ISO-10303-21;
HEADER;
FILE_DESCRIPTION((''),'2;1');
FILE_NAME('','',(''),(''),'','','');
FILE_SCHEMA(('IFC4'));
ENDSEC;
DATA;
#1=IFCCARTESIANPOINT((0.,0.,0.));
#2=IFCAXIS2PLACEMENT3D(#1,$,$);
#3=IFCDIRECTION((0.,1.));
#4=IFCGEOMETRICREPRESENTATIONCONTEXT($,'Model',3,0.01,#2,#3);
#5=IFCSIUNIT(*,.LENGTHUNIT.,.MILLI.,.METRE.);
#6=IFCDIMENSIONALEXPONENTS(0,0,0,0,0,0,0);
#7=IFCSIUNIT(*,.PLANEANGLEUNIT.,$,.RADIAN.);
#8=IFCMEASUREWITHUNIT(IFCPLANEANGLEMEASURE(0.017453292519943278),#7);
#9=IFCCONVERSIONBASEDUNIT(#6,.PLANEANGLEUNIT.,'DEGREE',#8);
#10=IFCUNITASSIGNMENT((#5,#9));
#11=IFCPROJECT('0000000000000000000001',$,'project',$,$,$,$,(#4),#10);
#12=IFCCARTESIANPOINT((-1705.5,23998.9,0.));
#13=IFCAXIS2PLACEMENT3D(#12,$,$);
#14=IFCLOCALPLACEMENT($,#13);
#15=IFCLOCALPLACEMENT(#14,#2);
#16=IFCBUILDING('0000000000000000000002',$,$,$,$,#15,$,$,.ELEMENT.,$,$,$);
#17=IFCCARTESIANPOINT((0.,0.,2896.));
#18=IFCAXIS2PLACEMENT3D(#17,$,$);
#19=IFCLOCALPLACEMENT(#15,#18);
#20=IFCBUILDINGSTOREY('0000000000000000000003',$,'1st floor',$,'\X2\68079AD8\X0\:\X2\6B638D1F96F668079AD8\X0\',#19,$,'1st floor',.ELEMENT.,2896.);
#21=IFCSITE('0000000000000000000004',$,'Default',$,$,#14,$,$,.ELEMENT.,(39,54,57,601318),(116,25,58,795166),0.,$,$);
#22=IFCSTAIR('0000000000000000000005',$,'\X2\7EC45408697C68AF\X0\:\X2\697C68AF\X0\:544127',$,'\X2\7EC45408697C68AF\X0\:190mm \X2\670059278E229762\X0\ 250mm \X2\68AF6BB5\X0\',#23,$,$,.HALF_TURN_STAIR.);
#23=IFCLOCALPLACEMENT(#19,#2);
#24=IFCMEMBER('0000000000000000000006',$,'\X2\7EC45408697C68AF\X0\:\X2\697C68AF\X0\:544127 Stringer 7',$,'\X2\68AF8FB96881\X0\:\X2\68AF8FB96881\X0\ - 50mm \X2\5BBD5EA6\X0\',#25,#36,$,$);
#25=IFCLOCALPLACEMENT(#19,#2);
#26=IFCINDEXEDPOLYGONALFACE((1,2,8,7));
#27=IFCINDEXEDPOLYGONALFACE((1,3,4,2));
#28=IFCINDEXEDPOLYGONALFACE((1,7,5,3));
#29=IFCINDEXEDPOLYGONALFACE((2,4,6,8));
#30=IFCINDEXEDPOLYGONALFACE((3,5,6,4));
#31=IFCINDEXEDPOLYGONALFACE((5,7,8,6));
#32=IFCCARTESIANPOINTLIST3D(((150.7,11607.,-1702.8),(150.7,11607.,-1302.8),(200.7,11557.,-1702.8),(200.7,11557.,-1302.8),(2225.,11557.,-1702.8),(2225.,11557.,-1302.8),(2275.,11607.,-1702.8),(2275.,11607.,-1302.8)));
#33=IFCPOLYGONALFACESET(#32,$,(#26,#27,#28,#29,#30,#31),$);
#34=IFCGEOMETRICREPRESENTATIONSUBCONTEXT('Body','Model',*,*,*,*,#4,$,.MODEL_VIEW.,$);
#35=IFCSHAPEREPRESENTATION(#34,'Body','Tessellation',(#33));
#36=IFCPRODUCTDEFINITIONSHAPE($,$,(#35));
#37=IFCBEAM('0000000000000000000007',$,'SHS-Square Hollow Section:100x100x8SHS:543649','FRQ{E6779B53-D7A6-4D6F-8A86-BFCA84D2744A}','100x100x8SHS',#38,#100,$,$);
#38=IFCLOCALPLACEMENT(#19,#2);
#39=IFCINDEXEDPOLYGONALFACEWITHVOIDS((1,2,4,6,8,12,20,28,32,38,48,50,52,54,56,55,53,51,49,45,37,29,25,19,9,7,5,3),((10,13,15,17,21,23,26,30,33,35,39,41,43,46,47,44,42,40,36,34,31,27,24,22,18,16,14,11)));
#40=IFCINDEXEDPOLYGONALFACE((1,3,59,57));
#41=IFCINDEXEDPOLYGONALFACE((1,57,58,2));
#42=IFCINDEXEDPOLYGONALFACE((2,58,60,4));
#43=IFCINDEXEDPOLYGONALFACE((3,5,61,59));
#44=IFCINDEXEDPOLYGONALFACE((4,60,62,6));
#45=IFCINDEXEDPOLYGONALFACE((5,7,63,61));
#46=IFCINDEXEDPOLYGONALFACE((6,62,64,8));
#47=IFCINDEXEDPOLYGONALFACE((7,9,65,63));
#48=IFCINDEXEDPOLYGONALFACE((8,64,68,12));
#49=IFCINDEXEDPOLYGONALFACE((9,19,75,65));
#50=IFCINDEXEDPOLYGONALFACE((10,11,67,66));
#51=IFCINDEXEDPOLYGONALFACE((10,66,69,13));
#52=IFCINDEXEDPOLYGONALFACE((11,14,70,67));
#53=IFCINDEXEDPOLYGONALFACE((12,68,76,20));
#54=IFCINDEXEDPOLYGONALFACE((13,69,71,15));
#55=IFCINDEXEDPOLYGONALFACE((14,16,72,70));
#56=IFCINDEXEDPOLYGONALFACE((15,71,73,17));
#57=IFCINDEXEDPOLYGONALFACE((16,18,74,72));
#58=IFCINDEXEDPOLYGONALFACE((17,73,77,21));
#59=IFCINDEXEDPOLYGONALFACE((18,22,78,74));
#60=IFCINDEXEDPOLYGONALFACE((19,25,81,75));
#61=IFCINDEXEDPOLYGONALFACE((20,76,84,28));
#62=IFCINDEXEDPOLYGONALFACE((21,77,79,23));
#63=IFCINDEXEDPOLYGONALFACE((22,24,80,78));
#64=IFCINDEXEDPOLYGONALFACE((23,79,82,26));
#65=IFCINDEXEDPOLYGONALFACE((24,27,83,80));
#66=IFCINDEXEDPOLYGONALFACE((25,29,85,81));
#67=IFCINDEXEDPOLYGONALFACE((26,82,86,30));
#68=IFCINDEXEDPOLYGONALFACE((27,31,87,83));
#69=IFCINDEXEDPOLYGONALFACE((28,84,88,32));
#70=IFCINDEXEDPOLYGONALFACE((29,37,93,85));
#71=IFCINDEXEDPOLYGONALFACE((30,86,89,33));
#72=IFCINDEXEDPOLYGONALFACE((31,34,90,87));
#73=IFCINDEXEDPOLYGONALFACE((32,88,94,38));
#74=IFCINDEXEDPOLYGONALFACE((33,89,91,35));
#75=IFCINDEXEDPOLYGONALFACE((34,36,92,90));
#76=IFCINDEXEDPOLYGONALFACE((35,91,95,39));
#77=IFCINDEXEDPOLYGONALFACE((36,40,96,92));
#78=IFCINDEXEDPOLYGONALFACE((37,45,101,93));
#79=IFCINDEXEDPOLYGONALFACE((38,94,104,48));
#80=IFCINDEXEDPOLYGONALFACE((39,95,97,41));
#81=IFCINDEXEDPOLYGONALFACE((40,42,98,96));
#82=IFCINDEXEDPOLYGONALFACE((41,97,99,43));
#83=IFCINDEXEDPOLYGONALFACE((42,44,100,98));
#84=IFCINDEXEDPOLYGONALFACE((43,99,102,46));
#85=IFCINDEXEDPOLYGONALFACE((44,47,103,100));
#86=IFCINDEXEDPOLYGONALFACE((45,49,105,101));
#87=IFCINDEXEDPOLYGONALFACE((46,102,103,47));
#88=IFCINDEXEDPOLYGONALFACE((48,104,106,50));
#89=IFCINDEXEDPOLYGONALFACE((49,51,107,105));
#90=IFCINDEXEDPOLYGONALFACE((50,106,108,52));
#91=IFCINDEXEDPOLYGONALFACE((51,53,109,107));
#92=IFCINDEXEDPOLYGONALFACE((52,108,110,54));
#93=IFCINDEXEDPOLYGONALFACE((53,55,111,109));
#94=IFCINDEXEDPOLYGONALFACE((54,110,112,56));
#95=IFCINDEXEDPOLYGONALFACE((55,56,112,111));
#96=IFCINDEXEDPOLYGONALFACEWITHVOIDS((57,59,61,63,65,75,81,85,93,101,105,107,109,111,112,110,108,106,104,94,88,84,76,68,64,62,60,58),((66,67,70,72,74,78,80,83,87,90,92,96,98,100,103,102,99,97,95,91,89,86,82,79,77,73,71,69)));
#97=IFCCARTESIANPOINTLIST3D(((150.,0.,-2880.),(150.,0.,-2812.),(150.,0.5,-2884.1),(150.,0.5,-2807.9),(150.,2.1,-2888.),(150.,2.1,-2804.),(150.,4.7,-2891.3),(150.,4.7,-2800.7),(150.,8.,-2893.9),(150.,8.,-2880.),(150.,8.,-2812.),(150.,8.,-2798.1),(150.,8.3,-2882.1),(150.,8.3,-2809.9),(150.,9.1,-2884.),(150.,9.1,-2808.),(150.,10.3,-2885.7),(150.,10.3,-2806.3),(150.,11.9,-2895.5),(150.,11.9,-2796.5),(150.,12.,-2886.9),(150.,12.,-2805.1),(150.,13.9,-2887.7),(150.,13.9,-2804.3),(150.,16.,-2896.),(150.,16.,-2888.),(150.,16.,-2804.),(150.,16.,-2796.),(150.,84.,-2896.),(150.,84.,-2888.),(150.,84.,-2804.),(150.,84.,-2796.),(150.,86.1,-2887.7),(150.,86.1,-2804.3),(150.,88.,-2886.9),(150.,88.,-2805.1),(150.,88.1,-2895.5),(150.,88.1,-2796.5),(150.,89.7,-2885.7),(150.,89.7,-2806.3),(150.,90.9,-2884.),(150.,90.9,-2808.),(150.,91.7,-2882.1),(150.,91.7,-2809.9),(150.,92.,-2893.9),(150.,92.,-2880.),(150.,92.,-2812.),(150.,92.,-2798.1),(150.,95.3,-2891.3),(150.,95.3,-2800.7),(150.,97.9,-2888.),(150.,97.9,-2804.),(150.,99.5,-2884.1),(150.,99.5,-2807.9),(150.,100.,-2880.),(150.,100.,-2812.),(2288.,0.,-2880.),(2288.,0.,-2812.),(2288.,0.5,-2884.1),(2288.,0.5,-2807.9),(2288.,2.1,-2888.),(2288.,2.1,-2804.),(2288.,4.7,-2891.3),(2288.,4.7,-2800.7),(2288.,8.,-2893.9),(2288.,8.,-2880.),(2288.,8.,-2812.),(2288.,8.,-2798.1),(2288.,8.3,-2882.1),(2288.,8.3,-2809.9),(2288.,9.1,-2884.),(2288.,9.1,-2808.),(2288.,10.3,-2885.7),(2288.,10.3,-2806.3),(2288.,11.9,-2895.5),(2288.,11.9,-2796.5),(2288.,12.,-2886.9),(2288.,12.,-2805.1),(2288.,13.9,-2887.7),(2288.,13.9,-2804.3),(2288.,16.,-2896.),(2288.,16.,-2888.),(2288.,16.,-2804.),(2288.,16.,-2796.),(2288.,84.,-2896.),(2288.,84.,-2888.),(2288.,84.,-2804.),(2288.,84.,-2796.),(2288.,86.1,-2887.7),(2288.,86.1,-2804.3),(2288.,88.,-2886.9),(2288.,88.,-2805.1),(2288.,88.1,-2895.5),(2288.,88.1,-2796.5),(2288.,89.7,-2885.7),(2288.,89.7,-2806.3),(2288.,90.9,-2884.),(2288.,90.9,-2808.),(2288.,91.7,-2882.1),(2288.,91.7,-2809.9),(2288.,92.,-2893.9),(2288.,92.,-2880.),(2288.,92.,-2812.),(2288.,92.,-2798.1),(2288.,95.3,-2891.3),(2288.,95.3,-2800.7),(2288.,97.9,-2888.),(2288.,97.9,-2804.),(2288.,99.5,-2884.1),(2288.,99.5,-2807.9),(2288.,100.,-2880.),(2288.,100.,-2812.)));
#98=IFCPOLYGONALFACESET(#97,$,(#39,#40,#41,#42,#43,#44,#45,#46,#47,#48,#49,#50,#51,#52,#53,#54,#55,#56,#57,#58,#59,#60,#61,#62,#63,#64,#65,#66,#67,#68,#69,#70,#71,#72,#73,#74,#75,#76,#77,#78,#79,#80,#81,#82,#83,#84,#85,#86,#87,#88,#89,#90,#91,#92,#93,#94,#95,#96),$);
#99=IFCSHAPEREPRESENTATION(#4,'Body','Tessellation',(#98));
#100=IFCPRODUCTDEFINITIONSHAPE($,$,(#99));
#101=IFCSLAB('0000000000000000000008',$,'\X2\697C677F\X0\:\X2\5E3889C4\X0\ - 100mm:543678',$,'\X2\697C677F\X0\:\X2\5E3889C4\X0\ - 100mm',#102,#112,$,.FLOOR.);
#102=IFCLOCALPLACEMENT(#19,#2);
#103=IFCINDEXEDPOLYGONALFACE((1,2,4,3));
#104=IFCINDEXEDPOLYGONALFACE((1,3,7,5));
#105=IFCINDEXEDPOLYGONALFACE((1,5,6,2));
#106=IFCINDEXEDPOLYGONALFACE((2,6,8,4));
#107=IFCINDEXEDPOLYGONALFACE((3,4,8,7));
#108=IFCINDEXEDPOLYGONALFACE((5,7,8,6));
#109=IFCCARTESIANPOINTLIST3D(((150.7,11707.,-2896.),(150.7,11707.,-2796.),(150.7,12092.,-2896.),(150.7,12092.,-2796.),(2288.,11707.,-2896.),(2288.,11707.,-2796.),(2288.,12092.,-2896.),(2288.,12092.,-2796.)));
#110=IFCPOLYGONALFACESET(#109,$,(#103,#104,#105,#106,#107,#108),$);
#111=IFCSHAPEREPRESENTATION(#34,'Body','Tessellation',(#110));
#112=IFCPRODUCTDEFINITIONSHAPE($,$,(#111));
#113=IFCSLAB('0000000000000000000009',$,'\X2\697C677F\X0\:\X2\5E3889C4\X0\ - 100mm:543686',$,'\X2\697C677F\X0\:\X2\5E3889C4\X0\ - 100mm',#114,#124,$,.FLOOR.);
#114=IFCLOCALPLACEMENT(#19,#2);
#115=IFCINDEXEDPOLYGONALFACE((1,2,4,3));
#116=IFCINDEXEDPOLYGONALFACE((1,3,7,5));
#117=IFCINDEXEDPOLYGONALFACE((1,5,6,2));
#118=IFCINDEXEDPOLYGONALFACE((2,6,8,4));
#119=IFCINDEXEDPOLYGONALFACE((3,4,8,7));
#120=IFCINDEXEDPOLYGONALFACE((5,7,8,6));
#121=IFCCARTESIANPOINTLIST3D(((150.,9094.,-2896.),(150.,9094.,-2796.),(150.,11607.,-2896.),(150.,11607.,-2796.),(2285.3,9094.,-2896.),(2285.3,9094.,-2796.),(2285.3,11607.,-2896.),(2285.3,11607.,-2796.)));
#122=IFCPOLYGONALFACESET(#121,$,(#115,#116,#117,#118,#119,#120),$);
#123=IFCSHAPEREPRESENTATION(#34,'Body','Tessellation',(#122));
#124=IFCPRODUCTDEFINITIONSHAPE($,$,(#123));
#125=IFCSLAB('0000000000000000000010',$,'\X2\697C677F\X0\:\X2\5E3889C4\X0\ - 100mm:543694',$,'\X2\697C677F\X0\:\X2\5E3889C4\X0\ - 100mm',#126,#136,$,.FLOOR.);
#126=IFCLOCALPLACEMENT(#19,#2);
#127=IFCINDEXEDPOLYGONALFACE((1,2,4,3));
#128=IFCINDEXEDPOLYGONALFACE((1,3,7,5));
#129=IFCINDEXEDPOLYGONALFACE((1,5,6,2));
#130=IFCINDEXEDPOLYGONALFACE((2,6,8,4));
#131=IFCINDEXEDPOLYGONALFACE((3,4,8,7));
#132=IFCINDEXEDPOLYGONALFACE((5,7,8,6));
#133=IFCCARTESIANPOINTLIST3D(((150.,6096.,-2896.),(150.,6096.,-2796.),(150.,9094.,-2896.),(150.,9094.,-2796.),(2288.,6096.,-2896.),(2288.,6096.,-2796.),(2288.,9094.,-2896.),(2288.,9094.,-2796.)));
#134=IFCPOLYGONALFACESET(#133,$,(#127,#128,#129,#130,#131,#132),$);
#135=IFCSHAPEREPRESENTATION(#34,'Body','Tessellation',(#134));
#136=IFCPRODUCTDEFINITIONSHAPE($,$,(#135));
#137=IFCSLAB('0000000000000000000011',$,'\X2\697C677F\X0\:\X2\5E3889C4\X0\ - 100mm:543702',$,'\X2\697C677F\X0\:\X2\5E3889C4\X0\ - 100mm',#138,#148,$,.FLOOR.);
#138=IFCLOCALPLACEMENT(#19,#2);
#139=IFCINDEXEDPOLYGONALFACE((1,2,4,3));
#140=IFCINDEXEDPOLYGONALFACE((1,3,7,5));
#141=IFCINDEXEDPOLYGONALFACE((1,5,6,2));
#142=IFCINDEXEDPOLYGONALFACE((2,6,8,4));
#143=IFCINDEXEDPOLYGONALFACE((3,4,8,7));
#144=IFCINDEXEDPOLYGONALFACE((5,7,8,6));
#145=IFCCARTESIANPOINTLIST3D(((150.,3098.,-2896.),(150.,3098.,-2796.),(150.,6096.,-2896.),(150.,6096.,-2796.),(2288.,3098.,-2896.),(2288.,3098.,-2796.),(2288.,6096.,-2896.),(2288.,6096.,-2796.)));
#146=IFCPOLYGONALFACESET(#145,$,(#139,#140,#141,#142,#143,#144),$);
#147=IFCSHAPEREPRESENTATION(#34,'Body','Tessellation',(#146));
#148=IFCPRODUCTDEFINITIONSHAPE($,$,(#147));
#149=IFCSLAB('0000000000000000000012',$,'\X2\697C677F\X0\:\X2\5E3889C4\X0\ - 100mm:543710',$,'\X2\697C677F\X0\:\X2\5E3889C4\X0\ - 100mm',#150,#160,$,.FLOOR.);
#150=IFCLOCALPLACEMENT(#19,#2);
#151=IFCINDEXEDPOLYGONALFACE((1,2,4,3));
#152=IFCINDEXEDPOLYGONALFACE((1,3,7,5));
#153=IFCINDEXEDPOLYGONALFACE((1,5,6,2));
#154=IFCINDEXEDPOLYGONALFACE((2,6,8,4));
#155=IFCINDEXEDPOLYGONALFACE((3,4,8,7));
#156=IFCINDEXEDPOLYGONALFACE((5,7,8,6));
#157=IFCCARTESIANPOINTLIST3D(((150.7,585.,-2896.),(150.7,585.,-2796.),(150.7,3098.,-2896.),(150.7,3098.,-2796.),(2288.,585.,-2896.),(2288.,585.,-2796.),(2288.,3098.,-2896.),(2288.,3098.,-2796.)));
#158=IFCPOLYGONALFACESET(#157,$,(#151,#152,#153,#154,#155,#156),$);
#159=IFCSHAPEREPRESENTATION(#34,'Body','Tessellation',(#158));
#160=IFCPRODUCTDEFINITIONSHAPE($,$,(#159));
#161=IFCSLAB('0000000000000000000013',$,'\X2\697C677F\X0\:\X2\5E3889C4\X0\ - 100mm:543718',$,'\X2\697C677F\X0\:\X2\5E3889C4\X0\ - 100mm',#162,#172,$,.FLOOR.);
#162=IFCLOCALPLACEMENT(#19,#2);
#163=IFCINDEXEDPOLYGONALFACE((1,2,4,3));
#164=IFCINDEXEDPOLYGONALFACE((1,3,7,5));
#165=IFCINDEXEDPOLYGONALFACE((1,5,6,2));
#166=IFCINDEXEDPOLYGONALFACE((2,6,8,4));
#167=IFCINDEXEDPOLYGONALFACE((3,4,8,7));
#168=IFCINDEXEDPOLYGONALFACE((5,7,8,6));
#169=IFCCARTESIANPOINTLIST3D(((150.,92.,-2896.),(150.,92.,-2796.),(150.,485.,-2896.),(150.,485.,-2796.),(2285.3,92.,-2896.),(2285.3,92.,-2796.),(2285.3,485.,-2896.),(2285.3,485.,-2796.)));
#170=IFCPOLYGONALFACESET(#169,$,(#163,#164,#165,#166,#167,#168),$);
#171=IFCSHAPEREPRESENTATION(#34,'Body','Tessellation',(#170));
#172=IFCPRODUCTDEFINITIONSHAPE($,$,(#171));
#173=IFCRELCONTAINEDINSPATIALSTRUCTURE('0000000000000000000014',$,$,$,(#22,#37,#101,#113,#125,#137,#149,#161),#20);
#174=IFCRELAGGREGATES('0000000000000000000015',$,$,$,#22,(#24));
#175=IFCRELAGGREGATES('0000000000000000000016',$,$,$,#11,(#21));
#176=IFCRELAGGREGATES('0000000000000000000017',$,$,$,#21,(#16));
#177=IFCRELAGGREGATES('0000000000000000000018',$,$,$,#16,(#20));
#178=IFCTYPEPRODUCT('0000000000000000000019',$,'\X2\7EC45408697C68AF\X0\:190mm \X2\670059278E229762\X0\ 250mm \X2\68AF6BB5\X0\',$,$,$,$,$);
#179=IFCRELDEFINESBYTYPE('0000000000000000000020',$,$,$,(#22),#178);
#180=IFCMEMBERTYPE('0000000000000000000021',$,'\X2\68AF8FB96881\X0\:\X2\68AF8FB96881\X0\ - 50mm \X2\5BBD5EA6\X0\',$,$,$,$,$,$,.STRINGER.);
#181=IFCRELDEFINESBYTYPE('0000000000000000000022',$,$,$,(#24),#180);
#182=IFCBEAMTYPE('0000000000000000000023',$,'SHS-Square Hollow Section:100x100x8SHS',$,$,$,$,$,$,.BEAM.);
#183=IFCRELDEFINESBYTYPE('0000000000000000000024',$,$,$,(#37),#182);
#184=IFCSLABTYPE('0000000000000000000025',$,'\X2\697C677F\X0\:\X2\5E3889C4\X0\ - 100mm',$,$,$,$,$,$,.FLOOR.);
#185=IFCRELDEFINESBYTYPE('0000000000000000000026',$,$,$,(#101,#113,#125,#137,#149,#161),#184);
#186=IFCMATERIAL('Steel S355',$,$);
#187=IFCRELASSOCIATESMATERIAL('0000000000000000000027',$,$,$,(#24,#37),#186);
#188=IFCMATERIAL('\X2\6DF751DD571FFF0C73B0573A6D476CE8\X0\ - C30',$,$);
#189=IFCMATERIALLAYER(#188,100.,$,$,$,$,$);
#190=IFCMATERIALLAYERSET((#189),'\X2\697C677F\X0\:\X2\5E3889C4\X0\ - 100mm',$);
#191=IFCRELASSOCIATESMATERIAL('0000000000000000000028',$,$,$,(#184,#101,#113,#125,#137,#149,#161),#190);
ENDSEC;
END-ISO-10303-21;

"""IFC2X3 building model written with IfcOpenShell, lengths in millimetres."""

from ifc_helpers import new_model, entity, si_unit, converted_unit, direction, frame, frame_2d, origin, origin_2d, origin_2d_with_axis, place, context, subcontext, project, spatial, polyline, rectangle, hollow_rectangle, outline, extrude, clip, halfspace, material, layer, layer_set, layer_usage, type_object, element, aggregate, save


model = new_model("IFC2X3")

# Units and contexts
model_context = context("Model", 3, precision=0.01, world=origin(), true_north=direction((0.0, 1.0)))
body_context = subcontext(model_context, "Body", "Model", "MODEL_VIEW")
ifc_project = project(units=[si_unit("LENGTHUNIT", "METRE", prefix="MILLI"), converted_unit("PLANEANGLEUNIT", "DEGREE", entity("IfcPlaneAngleMeasure", 0.017453292519943278), si_unit("PLANEANGLEUNIT", "RADIAN"), dimensions=[0, 0, 0, 0, 0, 0, 0])], contexts=[model_context])

# Site, building, storey
site_placement = place(None, frame((-1705.5, 23998.9, 0.0)))
site = spatial("IfcSite", under=ifc_project, at=site_placement, Name="Default", CompositionType="ELEMENT", RefLatitude=(39, 54, 57, 601318), RefLongitude=(116, 25, 58, 795166), RefElevation=0.0)
building_placement = place(site_placement, origin())
building = spatial("IfcBuilding", under=site, at=building_placement, CompositionType="ELEMENT")
storey_placement = place(building_placement, frame((0.0, 0.0, 2896.0)))
storey = spatial("IfcBuildingStorey", under=building, at=storey_placement, Name="1st floor", ObjectType="标高:正负零标高", LongName="1st floor", CompositionType="ELEMENT", Elevation=2896.0)

# Shared definitions
ifc_material_1 = material(Name="Steel S355")

# Stair, member
type_product = type_object("IfcTypeProduct", Name="组合楼梯:190mm 最大踢面 250mm 梯段")
stair_placement = place(storey_placement, origin())
stair = element("IfcStair", 1, at=stair_placement, inside=storey, type_object=type_product, Name="组合楼梯:楼梯:544127", ObjectType="组合楼梯:190mm 最大踢面 250mm 梯段", ShapeType="HALF_TURN_STAIR")
member_type = type_object("IfcMemberType", Name="梯边梁:梯边梁 - 50mm 宽度", PredefinedType="STRINGER")
member_1_placement = place(stair_placement, origin())
member_1 = element("IfcMember", 2, at=member_1_placement, type_object=member_type, material=ifc_material_1, Name="组合楼梯:楼梯:544127 Stringer 7", ObjectType="梯边梁:梯边梁 - 50mm 宽度", context=body_context, shape_type="SweptSolid", body=[
    extrude(outline(polyline([(-1062.2, -25.0), (1062.2, -25.0), (1012.2, 25.0), (-1012.2, 25.0), (-1062.2, -25.0)])), frame((1212.8, 11582.0, -1702.8), z_axis=(0.0, 0.0, 1.0), x_axis=(-1.0, 0.0, 0.0)), (0.0, 0.0, 1.0), 400.0),
])

# Beam
beam_type_1 = type_object("IfcBeamType", Name="SHS-Square Hollow Section:100x100x8SHS", PredefinedType="BEAM")
beam_1_placement = place(storey_placement, frame((-57.7, 50.0, -2846.0), z_axis=(-1.0, 0.0, 0.0), x_axis=(0.0, -1.0, 0.0)))
element("IfcBeam", 3, at=beam_1_placement, inside=storey, type_object=beam_type_1, material=ifc_material_1, Name="SHS-Square Hollow Section:100x100x8SHS:543649", Description="FRQ{E6779B53-D7A6-4D6F-8A86-BFCA84D2744A}", ObjectType="100x100x8SHS", context=model_context, shape_type="Clipping", body=[
    clip(clip(extrude(hollow_rectangle(XDim=100.0, YDim=100.0, WallThickness=8.0, InnerFilletRadius=8.0, OuterFilletRadius=16.0, at=origin_2d()), origin(), (0.0, 0.0, -1.0), 2551.4), halfspace(frame((50.0, -50.0, -2345.7), z_axis=(0.0, 0.0, 1.0), x_axis=(1.0, 0.0, 0.0)), True)), halfspace(frame((50.0, -50.0, -207.7), z_axis=(0.0, 0.0, -1.0), x_axis=(-1.0, 0.0, 0.0)), True)),
])

# Slabs
ifc_material_2 = material(Name="混凝土，现场浇注 - C30")
ifc_layer_1 = layer(ifc_material_2, 100.0)
ifc_layer_set_1 = layer_set([ifc_layer_1], Name="楼板:常规 - 100mm")
ifc_layer_usage_1 = layer_usage(ifc_layer_set_1, "AXIS3", "POSITIVE", 0.0)
slab_type_1 = type_object("IfcSlabType", Name="楼板:常规 - 100mm", PredefinedType="FLOOR", material=ifc_layer_set_1)
slab_1_placement = place(storey_placement, origin())
element("IfcSlab", 4, at=slab_1_placement, inside=storey, type_object=slab_type_1, material=ifc_layer_usage_1, Name="楼板:常规 - 100mm:543678", ObjectType="楼板:常规 - 100mm", PredefinedType="FLOOR", context=body_context, shape_type="SweptSolid", body=[
    extrude(rectangle(XDim=385.0, YDim=2137.3, at=origin_2d_with_axis()), frame((1219.3, 11899.5, -2796.0), z_axis=(0.0, 0.0, -1.0), x_axis=(0.0, 1.0, 0.0)), (0.0, 0.0, 1.0), 100.0),
])
ifc_layer_usage_2 = layer_usage(ifc_layer_set_1, "AXIS3", "POSITIVE", 0.0)
slab_2_placement = place(storey_placement, origin())
element("IfcSlab", 5, at=slab_2_placement, inside=storey, type_object=slab_type_1, material=ifc_layer_usage_2, Name="楼板:常规 - 100mm:543686", ObjectType="楼板:常规 - 100mm", PredefinedType="FLOOR", context=body_context, shape_type="SweptSolid", body=[
    extrude(rectangle(XDim=2513.0, YDim=2135.3, at=frame_2d((0.0, 0.0), x_axis=(1.0, 0.0))), frame((1217.6, 10350.5, -2796.0), z_axis=(0.0, 0.0, -1.0), x_axis=(0.0, 1.0, 0.0)), (0.0, 0.0, 1.0), 100.0),
])
ifc_layer_usage_3 = layer_usage(ifc_layer_set_1, "AXIS3", "POSITIVE", 0.0)
slab_3_placement = place(storey_placement, origin())
element("IfcSlab", 6, at=slab_3_placement, inside=storey, type_object=slab_type_1, material=ifc_layer_usage_3, Name="楼板:常规 - 100mm:543694", ObjectType="楼板:常规 - 100mm", PredefinedType="FLOOR", context=body_context, shape_type="SweptSolid", body=[
    extrude(rectangle(XDim=2998.0, YDim=2138.0, at=origin_2d_with_axis()), frame((1219.0, 7595.0, -2796.0), z_axis=(0.0, 0.0, -1.0), x_axis=(0.0, 1.0, 0.0)), (0.0, 0.0, 1.0), 100.0),
])
ifc_layer_usage_4 = layer_usage(ifc_layer_set_1, "AXIS3", "POSITIVE", 0.0)
slab_4_placement = place(storey_placement, origin())
element("IfcSlab", 7, at=slab_4_placement, inside=storey, type_object=slab_type_1, material=ifc_layer_usage_4, Name="楼板:常规 - 100mm:543702", ObjectType="楼板:常规 - 100mm", PredefinedType="FLOOR", context=body_context, shape_type="SweptSolid", body=[
    extrude(rectangle(XDim=2998.0, YDim=2138.0, at=frame_2d((0.0, 0.0), x_axis=(1.0, 0.0))), frame((1219.0, 4597.0, -2796.0), z_axis=(0.0, 0.0, -1.0), x_axis=(0.0, 1.0, 0.0)), (0.0, 0.0, 1.0), 100.0),
])
ifc_layer_usage_5 = layer_usage(ifc_layer_set_1, "AXIS3", "POSITIVE", 0.0)
slab_5_placement = place(storey_placement, origin())
element("IfcSlab", 8, at=slab_5_placement, inside=storey, type_object=slab_type_1, material=ifc_layer_usage_5, Name="楼板:常规 - 100mm:543710", ObjectType="楼板:常规 - 100mm", PredefinedType="FLOOR", context=body_context, shape_type="SweptSolid", body=[
    extrude(rectangle(XDim=2513.0, YDim=2137.3, at=frame_2d((0.0, 0.0), x_axis=(1.0, 0.0))), frame((1219.3, 1841.5, -2796.0), z_axis=(0.0, 0.0, -1.0), x_axis=(0.0, 1.0, 0.0)), (0.0, 0.0, 1.0), 100.0),
])
ifc_layer_usage_6 = layer_usage(ifc_layer_set_1, "AXIS3", "POSITIVE", 0.0)
slab_6_placement = place(storey_placement, origin())
element("IfcSlab", 9, at=slab_6_placement, inside=storey, type_object=slab_type_1, material=ifc_layer_usage_6, Name="楼板:常规 - 100mm:543718", ObjectType="楼板:常规 - 100mm", PredefinedType="FLOOR", context=body_context, shape_type="SweptSolid", body=[
    extrude(rectangle(XDim=393.0, YDim=2135.3, at=frame_2d((0.0, 0.0), x_axis=(1.0, 0.0))), frame((1217.7, 288.5, -2796.0), z_axis=(0.0, 0.0, -1.0), x_axis=(0.0, 1.0, 0.0)), (0.0, 0.0, 1.0), 100.0),
])

aggregate(stair, [member_1])

save(model, "model.ifc")
